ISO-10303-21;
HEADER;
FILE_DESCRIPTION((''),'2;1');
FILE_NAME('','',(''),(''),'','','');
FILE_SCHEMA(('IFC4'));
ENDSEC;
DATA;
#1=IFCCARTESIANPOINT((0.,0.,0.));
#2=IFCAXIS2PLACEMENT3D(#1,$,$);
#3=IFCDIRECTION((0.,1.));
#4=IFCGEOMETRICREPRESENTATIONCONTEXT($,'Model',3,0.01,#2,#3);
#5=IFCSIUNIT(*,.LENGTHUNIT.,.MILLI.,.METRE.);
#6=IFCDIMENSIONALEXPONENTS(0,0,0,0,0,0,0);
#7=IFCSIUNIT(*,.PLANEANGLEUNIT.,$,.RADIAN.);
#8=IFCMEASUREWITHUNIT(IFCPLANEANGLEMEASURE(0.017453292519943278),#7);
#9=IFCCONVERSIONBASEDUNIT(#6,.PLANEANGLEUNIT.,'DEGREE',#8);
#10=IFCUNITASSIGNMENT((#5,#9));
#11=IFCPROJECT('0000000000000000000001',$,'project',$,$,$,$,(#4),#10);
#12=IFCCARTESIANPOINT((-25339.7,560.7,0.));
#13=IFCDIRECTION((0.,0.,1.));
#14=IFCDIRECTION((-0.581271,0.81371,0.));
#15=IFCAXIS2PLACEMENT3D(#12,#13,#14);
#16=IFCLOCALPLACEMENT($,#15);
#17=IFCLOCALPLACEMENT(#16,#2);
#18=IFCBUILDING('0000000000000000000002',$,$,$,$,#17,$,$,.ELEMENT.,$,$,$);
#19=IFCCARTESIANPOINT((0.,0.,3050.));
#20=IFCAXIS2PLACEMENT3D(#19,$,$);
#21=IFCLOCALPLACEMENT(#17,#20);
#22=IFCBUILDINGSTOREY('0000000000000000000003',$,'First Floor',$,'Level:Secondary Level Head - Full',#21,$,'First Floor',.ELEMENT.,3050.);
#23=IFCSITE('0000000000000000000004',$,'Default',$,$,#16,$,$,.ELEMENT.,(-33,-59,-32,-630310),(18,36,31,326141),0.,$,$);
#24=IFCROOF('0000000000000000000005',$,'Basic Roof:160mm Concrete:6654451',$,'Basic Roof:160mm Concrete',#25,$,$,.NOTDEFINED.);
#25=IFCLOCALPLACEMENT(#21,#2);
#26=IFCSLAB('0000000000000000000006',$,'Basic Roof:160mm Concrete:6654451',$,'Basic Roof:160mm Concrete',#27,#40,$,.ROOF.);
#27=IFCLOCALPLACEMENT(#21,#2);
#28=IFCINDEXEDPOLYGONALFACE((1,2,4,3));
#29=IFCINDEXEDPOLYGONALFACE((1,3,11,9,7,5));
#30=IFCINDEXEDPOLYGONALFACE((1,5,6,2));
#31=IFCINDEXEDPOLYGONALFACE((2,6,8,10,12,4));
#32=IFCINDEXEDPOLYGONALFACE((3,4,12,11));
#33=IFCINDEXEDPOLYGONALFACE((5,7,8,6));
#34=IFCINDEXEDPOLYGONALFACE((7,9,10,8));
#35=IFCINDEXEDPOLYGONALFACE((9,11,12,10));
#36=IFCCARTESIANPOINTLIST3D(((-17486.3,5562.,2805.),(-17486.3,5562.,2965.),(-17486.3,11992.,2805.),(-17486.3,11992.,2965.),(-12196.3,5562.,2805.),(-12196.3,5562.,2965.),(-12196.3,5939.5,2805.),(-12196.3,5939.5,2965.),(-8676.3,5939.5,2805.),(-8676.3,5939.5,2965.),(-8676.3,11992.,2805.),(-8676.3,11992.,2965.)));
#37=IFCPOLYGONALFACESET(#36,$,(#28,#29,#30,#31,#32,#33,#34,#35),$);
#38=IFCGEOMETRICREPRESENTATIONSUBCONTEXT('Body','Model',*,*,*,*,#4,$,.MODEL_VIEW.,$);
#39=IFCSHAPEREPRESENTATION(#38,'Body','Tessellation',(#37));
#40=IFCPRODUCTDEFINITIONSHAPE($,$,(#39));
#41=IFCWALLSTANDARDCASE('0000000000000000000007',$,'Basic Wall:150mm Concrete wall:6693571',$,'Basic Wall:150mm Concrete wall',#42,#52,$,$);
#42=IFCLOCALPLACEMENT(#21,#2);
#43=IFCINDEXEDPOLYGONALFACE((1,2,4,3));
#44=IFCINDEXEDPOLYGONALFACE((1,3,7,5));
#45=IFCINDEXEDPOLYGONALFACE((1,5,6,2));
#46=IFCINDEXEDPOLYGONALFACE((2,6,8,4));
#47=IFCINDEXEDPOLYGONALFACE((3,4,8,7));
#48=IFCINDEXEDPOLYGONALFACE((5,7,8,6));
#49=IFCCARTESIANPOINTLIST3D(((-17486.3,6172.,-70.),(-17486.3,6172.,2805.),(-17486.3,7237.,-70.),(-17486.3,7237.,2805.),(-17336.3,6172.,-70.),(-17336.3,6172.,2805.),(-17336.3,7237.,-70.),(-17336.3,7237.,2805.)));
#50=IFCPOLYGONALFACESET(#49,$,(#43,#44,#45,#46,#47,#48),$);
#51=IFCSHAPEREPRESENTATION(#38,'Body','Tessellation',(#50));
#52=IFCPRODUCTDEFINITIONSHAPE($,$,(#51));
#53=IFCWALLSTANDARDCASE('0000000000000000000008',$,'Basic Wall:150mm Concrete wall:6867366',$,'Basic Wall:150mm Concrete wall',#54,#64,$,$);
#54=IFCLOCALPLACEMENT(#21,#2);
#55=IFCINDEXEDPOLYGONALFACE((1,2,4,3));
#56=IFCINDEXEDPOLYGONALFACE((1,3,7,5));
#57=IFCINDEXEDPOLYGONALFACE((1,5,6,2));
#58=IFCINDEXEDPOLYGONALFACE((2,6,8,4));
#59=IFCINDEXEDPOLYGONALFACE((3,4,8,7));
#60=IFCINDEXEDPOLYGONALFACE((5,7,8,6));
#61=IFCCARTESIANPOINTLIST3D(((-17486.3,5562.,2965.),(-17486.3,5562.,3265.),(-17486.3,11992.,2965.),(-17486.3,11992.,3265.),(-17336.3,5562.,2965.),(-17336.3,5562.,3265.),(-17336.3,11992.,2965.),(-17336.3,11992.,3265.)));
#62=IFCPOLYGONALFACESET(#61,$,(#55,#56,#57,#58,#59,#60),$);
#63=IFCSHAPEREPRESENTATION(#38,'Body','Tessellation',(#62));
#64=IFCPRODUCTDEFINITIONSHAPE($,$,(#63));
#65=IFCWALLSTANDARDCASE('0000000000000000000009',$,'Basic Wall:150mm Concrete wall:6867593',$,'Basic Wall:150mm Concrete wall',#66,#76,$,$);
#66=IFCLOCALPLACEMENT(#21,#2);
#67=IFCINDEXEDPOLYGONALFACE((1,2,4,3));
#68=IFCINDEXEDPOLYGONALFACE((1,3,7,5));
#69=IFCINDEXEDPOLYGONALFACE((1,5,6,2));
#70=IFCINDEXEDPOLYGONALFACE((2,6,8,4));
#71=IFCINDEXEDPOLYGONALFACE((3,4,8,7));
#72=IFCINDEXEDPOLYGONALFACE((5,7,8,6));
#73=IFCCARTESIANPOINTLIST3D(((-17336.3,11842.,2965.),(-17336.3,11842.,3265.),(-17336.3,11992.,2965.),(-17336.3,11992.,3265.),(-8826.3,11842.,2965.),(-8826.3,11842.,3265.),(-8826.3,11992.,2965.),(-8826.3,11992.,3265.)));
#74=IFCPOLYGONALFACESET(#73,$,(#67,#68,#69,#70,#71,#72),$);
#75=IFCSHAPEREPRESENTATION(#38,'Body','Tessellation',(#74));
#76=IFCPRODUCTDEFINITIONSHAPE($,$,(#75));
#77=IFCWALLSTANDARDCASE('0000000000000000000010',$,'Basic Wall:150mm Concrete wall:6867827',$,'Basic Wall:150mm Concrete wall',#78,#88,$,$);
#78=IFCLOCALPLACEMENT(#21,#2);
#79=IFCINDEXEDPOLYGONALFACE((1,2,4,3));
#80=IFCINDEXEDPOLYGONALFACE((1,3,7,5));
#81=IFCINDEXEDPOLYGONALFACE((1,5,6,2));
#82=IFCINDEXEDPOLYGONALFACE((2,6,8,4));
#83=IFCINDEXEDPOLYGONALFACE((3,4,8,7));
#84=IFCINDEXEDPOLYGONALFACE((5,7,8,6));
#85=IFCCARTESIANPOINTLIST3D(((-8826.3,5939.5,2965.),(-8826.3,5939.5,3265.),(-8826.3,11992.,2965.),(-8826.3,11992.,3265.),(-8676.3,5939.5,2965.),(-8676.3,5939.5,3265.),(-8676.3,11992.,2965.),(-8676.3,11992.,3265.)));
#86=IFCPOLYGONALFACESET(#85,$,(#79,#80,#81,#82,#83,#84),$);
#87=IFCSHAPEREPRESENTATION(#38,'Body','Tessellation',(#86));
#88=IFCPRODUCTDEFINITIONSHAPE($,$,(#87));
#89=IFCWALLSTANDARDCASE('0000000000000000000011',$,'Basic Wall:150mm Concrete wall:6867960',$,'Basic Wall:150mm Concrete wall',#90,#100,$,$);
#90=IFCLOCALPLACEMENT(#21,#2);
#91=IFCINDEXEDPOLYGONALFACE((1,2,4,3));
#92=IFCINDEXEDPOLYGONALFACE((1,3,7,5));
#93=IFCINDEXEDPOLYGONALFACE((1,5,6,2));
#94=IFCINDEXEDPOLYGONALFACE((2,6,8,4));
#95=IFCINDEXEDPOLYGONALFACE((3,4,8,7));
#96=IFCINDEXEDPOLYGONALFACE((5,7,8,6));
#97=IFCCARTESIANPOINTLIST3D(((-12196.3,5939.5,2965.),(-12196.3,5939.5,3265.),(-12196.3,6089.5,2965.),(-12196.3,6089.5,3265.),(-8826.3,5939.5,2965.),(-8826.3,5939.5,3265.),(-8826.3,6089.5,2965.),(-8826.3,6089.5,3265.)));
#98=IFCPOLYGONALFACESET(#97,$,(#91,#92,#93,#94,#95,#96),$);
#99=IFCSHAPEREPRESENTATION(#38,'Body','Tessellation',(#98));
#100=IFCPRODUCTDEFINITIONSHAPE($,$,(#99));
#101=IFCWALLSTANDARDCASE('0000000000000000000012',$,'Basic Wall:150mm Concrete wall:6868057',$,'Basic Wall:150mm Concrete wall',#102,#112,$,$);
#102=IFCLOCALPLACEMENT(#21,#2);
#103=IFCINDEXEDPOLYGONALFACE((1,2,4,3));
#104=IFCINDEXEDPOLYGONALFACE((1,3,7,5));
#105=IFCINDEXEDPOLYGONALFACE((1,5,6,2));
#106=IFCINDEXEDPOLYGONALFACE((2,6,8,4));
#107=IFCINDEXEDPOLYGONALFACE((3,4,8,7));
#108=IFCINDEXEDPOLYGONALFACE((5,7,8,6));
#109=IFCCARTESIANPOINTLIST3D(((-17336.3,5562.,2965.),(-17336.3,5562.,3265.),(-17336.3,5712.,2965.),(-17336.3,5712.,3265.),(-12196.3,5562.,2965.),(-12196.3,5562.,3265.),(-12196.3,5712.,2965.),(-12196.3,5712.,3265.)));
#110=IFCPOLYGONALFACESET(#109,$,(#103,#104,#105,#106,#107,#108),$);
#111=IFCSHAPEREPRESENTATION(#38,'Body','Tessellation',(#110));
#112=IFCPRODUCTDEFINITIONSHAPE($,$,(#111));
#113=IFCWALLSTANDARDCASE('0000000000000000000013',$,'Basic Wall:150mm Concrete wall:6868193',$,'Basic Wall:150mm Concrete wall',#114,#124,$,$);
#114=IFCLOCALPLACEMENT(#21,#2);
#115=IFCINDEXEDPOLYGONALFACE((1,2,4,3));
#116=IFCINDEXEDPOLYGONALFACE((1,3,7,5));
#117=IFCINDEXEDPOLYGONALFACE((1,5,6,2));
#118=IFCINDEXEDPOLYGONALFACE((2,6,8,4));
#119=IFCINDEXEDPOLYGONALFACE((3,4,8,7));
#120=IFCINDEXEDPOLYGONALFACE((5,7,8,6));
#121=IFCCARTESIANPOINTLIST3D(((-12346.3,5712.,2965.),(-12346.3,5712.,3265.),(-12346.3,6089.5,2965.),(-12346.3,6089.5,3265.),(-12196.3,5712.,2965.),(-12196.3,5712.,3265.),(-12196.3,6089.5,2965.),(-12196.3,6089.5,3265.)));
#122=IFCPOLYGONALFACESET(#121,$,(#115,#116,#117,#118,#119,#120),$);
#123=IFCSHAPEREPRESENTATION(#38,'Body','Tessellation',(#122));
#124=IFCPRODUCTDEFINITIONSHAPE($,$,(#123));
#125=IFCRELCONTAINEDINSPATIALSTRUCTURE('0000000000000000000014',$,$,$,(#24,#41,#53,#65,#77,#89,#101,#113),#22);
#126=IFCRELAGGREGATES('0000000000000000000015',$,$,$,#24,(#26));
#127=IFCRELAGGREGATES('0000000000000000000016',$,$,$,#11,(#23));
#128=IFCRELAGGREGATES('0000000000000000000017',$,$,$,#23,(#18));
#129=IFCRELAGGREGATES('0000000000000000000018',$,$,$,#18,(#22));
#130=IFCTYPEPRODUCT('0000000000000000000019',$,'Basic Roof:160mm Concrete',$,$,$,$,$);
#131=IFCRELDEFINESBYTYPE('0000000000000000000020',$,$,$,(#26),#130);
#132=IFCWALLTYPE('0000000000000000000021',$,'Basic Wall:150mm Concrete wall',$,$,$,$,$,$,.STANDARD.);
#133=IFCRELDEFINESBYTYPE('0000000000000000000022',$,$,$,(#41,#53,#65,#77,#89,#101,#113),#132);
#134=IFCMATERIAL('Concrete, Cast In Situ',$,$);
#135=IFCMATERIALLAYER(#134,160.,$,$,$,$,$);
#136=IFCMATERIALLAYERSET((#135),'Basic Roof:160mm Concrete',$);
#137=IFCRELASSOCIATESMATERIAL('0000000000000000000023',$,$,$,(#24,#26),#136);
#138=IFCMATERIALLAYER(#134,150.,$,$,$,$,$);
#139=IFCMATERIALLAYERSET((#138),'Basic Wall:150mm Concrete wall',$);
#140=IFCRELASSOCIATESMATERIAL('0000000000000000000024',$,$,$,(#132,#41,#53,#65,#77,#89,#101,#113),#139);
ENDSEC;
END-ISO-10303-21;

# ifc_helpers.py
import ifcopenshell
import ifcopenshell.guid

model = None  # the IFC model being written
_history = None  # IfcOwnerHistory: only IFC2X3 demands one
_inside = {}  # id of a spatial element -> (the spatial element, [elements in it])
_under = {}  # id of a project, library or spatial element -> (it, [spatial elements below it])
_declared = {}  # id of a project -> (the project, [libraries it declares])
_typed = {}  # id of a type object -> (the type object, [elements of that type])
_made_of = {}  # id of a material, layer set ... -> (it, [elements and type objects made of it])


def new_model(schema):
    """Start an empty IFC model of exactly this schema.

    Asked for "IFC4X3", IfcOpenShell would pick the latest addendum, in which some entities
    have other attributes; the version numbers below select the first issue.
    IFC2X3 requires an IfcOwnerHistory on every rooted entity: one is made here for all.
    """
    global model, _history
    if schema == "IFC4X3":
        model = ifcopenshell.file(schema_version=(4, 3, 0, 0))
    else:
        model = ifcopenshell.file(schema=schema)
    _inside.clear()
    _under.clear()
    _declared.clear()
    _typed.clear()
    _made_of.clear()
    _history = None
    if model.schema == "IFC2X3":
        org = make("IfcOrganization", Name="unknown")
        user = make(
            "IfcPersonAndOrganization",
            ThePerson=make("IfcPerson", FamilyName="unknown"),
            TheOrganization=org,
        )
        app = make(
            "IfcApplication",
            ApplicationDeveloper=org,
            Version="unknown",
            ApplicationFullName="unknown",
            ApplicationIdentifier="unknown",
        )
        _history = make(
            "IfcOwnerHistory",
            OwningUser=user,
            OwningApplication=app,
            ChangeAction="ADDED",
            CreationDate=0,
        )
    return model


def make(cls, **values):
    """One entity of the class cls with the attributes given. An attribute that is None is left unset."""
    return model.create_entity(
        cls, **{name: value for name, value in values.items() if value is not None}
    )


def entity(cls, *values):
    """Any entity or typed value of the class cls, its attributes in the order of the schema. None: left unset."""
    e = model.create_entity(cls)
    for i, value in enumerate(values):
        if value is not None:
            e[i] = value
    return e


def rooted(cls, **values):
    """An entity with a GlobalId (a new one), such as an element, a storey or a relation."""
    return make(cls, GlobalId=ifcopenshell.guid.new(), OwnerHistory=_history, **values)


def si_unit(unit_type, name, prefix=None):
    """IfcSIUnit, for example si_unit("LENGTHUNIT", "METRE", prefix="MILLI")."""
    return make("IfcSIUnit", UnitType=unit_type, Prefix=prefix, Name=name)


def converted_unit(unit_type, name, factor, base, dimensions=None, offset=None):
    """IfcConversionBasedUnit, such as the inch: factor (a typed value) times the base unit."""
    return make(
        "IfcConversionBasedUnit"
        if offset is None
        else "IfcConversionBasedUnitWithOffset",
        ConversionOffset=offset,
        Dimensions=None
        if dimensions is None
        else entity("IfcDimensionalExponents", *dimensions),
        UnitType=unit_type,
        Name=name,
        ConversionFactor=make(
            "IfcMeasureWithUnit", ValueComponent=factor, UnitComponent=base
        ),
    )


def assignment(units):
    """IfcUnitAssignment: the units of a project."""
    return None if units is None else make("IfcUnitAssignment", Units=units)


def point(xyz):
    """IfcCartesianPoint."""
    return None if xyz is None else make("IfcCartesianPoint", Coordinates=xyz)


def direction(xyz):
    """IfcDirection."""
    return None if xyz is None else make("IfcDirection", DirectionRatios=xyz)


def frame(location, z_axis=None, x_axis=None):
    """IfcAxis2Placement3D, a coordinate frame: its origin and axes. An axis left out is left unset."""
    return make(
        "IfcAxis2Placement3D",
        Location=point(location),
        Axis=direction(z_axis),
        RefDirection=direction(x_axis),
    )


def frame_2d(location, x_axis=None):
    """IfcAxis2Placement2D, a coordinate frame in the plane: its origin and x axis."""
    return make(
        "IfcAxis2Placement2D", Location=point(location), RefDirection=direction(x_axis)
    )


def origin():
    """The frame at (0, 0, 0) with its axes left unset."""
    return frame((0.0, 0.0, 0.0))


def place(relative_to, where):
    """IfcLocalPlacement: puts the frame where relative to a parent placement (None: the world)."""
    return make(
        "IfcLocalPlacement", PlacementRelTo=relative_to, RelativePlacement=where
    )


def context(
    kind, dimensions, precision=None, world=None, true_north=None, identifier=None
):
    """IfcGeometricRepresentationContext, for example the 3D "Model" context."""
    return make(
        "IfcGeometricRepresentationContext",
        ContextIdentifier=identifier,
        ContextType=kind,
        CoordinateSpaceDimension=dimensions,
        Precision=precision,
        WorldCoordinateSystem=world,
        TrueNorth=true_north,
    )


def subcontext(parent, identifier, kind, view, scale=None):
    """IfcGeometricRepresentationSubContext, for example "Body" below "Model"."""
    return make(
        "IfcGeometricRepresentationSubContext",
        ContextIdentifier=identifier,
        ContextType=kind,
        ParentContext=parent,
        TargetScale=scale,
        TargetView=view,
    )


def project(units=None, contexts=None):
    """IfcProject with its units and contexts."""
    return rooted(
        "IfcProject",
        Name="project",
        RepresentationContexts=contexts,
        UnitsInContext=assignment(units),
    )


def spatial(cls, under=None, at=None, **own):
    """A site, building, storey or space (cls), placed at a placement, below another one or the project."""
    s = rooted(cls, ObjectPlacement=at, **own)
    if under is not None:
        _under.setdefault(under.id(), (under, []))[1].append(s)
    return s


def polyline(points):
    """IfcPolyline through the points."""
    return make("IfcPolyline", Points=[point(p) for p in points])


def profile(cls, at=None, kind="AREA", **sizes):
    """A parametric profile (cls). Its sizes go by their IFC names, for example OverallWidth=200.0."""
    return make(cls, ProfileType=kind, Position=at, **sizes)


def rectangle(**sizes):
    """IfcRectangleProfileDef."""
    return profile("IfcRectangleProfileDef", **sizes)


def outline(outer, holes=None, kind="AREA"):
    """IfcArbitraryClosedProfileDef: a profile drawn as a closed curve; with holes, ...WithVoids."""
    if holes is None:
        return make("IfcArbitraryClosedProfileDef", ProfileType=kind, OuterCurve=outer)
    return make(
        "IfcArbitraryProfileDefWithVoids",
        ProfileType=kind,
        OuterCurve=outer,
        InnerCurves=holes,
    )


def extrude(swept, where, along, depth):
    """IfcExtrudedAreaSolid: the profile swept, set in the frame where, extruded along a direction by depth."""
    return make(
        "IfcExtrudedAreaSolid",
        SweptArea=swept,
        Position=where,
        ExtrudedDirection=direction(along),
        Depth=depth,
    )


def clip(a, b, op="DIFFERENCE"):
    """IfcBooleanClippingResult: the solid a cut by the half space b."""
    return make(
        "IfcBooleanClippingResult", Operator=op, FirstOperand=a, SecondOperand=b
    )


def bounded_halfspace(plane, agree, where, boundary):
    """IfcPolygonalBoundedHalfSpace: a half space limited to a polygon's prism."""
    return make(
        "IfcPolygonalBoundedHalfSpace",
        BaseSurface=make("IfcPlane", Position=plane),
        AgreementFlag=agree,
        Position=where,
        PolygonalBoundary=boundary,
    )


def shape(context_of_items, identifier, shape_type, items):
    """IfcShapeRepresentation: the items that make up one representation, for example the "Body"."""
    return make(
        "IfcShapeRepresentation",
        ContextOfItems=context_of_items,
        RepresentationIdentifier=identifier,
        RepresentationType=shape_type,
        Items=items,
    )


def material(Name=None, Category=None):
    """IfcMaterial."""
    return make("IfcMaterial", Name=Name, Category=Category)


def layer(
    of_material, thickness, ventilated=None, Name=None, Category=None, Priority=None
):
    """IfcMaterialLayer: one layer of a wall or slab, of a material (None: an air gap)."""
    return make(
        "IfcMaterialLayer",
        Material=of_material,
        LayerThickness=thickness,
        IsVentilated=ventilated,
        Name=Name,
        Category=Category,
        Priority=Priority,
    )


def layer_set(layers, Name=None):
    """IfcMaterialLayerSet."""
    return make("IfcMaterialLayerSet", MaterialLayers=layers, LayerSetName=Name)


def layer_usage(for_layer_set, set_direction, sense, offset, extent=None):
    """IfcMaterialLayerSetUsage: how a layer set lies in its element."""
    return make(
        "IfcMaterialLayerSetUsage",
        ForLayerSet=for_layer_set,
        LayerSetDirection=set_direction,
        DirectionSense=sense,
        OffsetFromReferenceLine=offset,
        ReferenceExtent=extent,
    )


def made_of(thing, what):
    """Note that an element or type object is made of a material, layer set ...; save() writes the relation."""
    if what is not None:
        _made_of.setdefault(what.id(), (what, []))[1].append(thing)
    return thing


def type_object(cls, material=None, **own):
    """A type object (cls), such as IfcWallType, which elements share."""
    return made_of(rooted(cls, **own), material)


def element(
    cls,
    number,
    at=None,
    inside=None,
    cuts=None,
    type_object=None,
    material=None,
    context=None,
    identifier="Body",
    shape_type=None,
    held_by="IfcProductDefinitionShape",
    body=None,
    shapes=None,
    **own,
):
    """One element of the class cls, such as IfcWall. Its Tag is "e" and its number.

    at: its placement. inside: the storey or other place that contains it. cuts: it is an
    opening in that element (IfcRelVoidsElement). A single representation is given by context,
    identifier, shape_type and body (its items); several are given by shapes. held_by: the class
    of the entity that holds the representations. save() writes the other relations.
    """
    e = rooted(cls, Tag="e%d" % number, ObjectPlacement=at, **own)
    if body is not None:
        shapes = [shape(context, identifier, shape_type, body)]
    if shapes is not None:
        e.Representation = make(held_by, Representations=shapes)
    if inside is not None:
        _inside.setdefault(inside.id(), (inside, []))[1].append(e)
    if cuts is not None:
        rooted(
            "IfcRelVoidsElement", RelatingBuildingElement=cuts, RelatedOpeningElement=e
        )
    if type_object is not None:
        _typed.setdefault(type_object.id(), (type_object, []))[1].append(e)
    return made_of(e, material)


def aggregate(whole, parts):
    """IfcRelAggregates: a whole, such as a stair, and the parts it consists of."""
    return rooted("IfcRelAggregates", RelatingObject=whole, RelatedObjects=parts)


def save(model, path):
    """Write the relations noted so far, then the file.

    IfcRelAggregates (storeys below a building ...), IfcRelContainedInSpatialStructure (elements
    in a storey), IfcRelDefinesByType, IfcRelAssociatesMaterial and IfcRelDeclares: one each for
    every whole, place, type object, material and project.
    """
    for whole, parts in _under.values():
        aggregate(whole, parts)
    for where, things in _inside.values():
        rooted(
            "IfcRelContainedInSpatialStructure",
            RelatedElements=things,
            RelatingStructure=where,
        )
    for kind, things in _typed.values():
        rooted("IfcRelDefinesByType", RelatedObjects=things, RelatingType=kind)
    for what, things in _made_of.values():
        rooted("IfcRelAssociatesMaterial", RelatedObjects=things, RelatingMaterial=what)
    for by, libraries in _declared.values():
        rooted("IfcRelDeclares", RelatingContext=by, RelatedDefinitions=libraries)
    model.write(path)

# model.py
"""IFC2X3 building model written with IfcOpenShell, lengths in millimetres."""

from ifc_helpers import new_model, entity, si_unit, converted_unit, direction, frame, frame_2d, origin, place, context, subcontext, project, spatial, polyline, rectangle, outline, extrude, clip, bounded_halfspace, material, layer, layer_set, layer_usage, type_object, element, aggregate, save


model = new_model("IFC2X3")

# Units and contexts
model_context = context("Model", 3, precision=0.01, world=origin(), true_north=direction((0.0, 1.0)))
body_context = subcontext(model_context, "Body", "Model", "MODEL_VIEW")
ifc_project = project(units=[si_unit("LENGTHUNIT", "METRE", prefix="MILLI"), converted_unit("PLANEANGLEUNIT", "DEGREE", entity("IfcPlaneAngleMeasure", 0.017453292519943278), si_unit("PLANEANGLEUNIT", "RADIAN"), dimensions=[0, 0, 0, 0, 0, 0, 0])], contexts=[model_context])

# Site, building, storey
site_placement = place(None, frame((-25339.7, 560.7, 0.0), z_axis=(0.0, 0.0, 1.0), x_axis=(-0.581271, 0.81371, 0.0)))
site = spatial("IfcSite", under=ifc_project, at=site_placement, Name="Default", CompositionType="ELEMENT", RefLatitude=(-33, -59, -32, -630310), RefLongitude=(18, 36, 31, 326141), RefElevation=0.0)
building_placement = place(site_placement, origin())
building = spatial("IfcBuilding", under=site, at=building_placement, CompositionType="ELEMENT")
storey_placement = place(building_placement, frame((0.0, 0.0, 3050.0)))
storey = spatial("IfcBuildingStorey", under=building, at=storey_placement, Name="First Floor", ObjectType="Level:Secondary Level Head - Full", LongName="First Floor", CompositionType="ELEMENT", Elevation=3050.0)

# Shared definitions
ifc_material = material(Name="Concrete, Cast In Situ")

# Roof, slab
ifc_layer_1 = layer(ifc_material, 160.0)
ifc_layer_set_1 = layer_set([ifc_layer_1], Name="Basic Roof:160mm Concrete")
roof_placement = place(storey_placement, frame((-17486.3, 5562.0, 2805.0)))
roof = element("IfcRoof", 1, at=roof_placement, inside=storey, material=ifc_layer_set_1, Name="Basic Roof:160mm Concrete:6654451", ObjectType="Basic Roof:160mm Concrete", ShapeType="NOTDEFINED")
type_product = type_object("IfcTypeProduct", Name="Basic Roof:160mm Concrete")
slab_1_placement = place(roof_placement, origin())
slab_1 = element("IfcSlab", 2, at=slab_1_placement, type_object=type_product, material=ifc_layer_set_1, Name="Basic Roof:160mm Concrete:6654451", ObjectType="Basic Roof:160mm Concrete", PredefinedType="ROOF", context=body_context, shape_type="SweptSolid", body=[
    extrude(outline(polyline([(-4405.0, 3215.0), (-4405.0, -3215.0), (885.0, -3215.0), (885.0, -2837.5), (4405.0, -2837.5), (4405.0, 3215.0), (-4405.0, 3215.0)])), frame((4405.0, 3215.0, 0.0)), (0.0, 0.0, 1.0), 160.0),
])
aggregate(roof, [slab_1])

# Walls
ifc_layer_2 = layer(ifc_material, 150.0)
ifc_layer_set_2 = layer_set([ifc_layer_2], Name="Basic Wall:150mm Concrete wall")
ifc_layer_usage_1 = layer_usage(ifc_layer_set_2, "AXIS2", "POSITIVE", -75.0)
wall_type = type_object("IfcWallType", Name="Basic Wall:150mm Concrete wall", PredefinedType="STANDARD", material=ifc_layer_set_2)
wall_1_placement = place(storey_placement, frame((-17411.3, 7237.0, -70.0), z_axis=(0.0, 0.0, 1.0), x_axis=(0.0, -1.0, 0.0)))
element("IfcWallStandardCase", 3, at=wall_1_placement, inside=storey, type_object=wall_type, material=ifc_layer_usage_1, Name="Basic Wall:150mm Concrete wall:6693571", ObjectType="Basic Wall:150mm Concrete wall", context=body_context, shape_type="Clipping", body=[
    clip(extrude(rectangle(XDim=1065.0, YDim=150.0, at=frame_2d((532.5, 0.0), x_axis=(-1.0, 0.0))), origin(), (0.0, 0.0, 1.0), 2875.0), bounded_halfspace(frame((0.0, -75.0, 2875.0), z_axis=(0.0, 0.0, 1.0), x_axis=(0.0, 1.0, 0.0)), False, frame((0.0, -75.0, 2875.0)), polyline([(0.0, 0.0), (1065.0, 0.0), (1065.0, 150.0), (0.0, 150.0), (0.0, 0.0)]))),
])
ifc_layer_usage_2 = layer_usage(ifc_layer_set_2, "AXIS2", "NEGATIVE", 75.0)
wall_2_placement = place(storey_placement, frame((-17411.3, 5562.0, 2965.0), z_axis=(0.0, 0.0, 1.0), x_axis=(0.0, 1.0, 0.0)))
element("IfcWallStandardCase", 4, at=wall_2_placement, inside=storey, type_object=wall_type, material=ifc_layer_usage_2, Name="Basic Wall:150mm Concrete wall:6867366", ObjectType="Basic Wall:150mm Concrete wall", context=body_context, shape_type="SweptSolid", body=[
    extrude(rectangle(XDim=6430.0, YDim=150.0, at=frame_2d((3215.0, 0.0), x_axis=(-1.0, 0.0))), origin(), (0.0, 0.0, 1.0), 300.0),
])
ifc_layer_usage_3 = layer_usage(ifc_layer_set_2, "AXIS2", "NEGATIVE", 75.0)
wall_3_placement = place(storey_placement, frame((-17336.3, 11917.0, 2965.0)))
element("IfcWallStandardCase", 5, at=wall_3_placement, inside=storey, type_object=wall_type, material=ifc_layer_usage_3, Name="Basic Wall:150mm Concrete wall:6867593", ObjectType="Basic Wall:150mm Concrete wall", context=body_context, shape_type="SweptSolid", body=[
    extrude(rectangle(XDim=8510.0, YDim=150.0, at=frame_2d((4255.0, 0.0), x_axis=(-1.0, 0.0))), origin(), (0.0, 0.0, 1.0), 300.0),
])
ifc_layer_usage_4 = layer_usage(ifc_layer_set_2, "AXIS2", "NEGATIVE", 75.0)
wall_4_placement = place(storey_placement, frame((-8751.3, 11992.0, 2965.0), z_axis=(0.0, 0.0, 1.0), x_axis=(0.0, -1.0, 0.0)))
element("IfcWallStandardCase", 6, at=wall_4_placement, inside=storey, type_object=wall_type, material=ifc_layer_usage_4, Name="Basic Wall:150mm Concrete wall:6867827", ObjectType="Basic Wall:150mm Concrete wall", context=body_context, shape_type="SweptSolid", body=[
    extrude(rectangle(XDim=6052.5, YDim=150.0, at=frame_2d((3026.3, 0.0), x_axis=(-1.0, 0.0))), origin(), (0.0, 0.0, 1.0), 300.0),
])
ifc_layer_usage_5 = layer_usage(ifc_layer_set_2, "AXIS2", "NEGATIVE", 75.0)
wall_5_placement = place(storey_placement, frame((-12196.3, 6014.5, 2965.0)))
element("IfcWallStandardCase", 7, at=wall_5_placement, inside=storey, type_object=wall_type, material=ifc_layer_usage_5, Name="Basic Wall:150mm Concrete wall:6867960", ObjectType="Basic Wall:150mm Concrete wall", context=body_context, shape_type="SweptSolid", body=[
    extrude(rectangle(XDim=3370.0, YDim=150.0, at=frame_2d((1685.0, 0.0), x_axis=(-1.0, 0.0))), origin(), (0.0, 0.0, 1.0), 300.0),
])
ifc_layer_usage_6 = layer_usage(ifc_layer_set_2, "AXIS2", "NEGATIVE", 75.0)
wall_6_placement = place(storey_placement, frame((-17336.3, 5637.0, 2965.0)))
element("IfcWallStandardCase", 8, at=wall_6_placement, inside=storey, type_object=wall_type, material=ifc_layer_usage_6, Name="Basic Wall:150mm Concrete wall:6868057", ObjectType="Basic Wall:150mm Concrete wall", context=body_context, shape_type="SweptSolid", body=[
    extrude(rectangle(XDim=5140.0, YDim=150.0, at=frame_2d((2570.0, 0.0), x_axis=(-1.0, 0.0))), origin(), (0.0, 0.0, 1.0), 300.0),
])
ifc_layer_usage_7 = layer_usage(ifc_layer_set_2, "AXIS2", "NEGATIVE", 75.0)
wall_7_placement = place(storey_placement, frame((-12271.3, 5712.0, 2965.0), z_axis=(0.0, 0.0, 1.0), x_axis=(0.0, 1.0, 0.0)))
element("IfcWallStandardCase", 9, at=wall_7_placement, inside=storey, type_object=wall_type, material=ifc_layer_usage_7, Name="Basic Wall:150mm Concrete wall:6868193", ObjectType="Basic Wall:150mm Concrete wall", context=body_context, shape_type="SweptSolid", body=[
    extrude(rectangle(XDim=377.5, YDim=150.0, at=frame_2d((188.7, 0.0), x_axis=(-1.0, 0.0))), origin(), (0.0, 0.0, 1.0), 300.0),
])

save(model, "model.ifc")
